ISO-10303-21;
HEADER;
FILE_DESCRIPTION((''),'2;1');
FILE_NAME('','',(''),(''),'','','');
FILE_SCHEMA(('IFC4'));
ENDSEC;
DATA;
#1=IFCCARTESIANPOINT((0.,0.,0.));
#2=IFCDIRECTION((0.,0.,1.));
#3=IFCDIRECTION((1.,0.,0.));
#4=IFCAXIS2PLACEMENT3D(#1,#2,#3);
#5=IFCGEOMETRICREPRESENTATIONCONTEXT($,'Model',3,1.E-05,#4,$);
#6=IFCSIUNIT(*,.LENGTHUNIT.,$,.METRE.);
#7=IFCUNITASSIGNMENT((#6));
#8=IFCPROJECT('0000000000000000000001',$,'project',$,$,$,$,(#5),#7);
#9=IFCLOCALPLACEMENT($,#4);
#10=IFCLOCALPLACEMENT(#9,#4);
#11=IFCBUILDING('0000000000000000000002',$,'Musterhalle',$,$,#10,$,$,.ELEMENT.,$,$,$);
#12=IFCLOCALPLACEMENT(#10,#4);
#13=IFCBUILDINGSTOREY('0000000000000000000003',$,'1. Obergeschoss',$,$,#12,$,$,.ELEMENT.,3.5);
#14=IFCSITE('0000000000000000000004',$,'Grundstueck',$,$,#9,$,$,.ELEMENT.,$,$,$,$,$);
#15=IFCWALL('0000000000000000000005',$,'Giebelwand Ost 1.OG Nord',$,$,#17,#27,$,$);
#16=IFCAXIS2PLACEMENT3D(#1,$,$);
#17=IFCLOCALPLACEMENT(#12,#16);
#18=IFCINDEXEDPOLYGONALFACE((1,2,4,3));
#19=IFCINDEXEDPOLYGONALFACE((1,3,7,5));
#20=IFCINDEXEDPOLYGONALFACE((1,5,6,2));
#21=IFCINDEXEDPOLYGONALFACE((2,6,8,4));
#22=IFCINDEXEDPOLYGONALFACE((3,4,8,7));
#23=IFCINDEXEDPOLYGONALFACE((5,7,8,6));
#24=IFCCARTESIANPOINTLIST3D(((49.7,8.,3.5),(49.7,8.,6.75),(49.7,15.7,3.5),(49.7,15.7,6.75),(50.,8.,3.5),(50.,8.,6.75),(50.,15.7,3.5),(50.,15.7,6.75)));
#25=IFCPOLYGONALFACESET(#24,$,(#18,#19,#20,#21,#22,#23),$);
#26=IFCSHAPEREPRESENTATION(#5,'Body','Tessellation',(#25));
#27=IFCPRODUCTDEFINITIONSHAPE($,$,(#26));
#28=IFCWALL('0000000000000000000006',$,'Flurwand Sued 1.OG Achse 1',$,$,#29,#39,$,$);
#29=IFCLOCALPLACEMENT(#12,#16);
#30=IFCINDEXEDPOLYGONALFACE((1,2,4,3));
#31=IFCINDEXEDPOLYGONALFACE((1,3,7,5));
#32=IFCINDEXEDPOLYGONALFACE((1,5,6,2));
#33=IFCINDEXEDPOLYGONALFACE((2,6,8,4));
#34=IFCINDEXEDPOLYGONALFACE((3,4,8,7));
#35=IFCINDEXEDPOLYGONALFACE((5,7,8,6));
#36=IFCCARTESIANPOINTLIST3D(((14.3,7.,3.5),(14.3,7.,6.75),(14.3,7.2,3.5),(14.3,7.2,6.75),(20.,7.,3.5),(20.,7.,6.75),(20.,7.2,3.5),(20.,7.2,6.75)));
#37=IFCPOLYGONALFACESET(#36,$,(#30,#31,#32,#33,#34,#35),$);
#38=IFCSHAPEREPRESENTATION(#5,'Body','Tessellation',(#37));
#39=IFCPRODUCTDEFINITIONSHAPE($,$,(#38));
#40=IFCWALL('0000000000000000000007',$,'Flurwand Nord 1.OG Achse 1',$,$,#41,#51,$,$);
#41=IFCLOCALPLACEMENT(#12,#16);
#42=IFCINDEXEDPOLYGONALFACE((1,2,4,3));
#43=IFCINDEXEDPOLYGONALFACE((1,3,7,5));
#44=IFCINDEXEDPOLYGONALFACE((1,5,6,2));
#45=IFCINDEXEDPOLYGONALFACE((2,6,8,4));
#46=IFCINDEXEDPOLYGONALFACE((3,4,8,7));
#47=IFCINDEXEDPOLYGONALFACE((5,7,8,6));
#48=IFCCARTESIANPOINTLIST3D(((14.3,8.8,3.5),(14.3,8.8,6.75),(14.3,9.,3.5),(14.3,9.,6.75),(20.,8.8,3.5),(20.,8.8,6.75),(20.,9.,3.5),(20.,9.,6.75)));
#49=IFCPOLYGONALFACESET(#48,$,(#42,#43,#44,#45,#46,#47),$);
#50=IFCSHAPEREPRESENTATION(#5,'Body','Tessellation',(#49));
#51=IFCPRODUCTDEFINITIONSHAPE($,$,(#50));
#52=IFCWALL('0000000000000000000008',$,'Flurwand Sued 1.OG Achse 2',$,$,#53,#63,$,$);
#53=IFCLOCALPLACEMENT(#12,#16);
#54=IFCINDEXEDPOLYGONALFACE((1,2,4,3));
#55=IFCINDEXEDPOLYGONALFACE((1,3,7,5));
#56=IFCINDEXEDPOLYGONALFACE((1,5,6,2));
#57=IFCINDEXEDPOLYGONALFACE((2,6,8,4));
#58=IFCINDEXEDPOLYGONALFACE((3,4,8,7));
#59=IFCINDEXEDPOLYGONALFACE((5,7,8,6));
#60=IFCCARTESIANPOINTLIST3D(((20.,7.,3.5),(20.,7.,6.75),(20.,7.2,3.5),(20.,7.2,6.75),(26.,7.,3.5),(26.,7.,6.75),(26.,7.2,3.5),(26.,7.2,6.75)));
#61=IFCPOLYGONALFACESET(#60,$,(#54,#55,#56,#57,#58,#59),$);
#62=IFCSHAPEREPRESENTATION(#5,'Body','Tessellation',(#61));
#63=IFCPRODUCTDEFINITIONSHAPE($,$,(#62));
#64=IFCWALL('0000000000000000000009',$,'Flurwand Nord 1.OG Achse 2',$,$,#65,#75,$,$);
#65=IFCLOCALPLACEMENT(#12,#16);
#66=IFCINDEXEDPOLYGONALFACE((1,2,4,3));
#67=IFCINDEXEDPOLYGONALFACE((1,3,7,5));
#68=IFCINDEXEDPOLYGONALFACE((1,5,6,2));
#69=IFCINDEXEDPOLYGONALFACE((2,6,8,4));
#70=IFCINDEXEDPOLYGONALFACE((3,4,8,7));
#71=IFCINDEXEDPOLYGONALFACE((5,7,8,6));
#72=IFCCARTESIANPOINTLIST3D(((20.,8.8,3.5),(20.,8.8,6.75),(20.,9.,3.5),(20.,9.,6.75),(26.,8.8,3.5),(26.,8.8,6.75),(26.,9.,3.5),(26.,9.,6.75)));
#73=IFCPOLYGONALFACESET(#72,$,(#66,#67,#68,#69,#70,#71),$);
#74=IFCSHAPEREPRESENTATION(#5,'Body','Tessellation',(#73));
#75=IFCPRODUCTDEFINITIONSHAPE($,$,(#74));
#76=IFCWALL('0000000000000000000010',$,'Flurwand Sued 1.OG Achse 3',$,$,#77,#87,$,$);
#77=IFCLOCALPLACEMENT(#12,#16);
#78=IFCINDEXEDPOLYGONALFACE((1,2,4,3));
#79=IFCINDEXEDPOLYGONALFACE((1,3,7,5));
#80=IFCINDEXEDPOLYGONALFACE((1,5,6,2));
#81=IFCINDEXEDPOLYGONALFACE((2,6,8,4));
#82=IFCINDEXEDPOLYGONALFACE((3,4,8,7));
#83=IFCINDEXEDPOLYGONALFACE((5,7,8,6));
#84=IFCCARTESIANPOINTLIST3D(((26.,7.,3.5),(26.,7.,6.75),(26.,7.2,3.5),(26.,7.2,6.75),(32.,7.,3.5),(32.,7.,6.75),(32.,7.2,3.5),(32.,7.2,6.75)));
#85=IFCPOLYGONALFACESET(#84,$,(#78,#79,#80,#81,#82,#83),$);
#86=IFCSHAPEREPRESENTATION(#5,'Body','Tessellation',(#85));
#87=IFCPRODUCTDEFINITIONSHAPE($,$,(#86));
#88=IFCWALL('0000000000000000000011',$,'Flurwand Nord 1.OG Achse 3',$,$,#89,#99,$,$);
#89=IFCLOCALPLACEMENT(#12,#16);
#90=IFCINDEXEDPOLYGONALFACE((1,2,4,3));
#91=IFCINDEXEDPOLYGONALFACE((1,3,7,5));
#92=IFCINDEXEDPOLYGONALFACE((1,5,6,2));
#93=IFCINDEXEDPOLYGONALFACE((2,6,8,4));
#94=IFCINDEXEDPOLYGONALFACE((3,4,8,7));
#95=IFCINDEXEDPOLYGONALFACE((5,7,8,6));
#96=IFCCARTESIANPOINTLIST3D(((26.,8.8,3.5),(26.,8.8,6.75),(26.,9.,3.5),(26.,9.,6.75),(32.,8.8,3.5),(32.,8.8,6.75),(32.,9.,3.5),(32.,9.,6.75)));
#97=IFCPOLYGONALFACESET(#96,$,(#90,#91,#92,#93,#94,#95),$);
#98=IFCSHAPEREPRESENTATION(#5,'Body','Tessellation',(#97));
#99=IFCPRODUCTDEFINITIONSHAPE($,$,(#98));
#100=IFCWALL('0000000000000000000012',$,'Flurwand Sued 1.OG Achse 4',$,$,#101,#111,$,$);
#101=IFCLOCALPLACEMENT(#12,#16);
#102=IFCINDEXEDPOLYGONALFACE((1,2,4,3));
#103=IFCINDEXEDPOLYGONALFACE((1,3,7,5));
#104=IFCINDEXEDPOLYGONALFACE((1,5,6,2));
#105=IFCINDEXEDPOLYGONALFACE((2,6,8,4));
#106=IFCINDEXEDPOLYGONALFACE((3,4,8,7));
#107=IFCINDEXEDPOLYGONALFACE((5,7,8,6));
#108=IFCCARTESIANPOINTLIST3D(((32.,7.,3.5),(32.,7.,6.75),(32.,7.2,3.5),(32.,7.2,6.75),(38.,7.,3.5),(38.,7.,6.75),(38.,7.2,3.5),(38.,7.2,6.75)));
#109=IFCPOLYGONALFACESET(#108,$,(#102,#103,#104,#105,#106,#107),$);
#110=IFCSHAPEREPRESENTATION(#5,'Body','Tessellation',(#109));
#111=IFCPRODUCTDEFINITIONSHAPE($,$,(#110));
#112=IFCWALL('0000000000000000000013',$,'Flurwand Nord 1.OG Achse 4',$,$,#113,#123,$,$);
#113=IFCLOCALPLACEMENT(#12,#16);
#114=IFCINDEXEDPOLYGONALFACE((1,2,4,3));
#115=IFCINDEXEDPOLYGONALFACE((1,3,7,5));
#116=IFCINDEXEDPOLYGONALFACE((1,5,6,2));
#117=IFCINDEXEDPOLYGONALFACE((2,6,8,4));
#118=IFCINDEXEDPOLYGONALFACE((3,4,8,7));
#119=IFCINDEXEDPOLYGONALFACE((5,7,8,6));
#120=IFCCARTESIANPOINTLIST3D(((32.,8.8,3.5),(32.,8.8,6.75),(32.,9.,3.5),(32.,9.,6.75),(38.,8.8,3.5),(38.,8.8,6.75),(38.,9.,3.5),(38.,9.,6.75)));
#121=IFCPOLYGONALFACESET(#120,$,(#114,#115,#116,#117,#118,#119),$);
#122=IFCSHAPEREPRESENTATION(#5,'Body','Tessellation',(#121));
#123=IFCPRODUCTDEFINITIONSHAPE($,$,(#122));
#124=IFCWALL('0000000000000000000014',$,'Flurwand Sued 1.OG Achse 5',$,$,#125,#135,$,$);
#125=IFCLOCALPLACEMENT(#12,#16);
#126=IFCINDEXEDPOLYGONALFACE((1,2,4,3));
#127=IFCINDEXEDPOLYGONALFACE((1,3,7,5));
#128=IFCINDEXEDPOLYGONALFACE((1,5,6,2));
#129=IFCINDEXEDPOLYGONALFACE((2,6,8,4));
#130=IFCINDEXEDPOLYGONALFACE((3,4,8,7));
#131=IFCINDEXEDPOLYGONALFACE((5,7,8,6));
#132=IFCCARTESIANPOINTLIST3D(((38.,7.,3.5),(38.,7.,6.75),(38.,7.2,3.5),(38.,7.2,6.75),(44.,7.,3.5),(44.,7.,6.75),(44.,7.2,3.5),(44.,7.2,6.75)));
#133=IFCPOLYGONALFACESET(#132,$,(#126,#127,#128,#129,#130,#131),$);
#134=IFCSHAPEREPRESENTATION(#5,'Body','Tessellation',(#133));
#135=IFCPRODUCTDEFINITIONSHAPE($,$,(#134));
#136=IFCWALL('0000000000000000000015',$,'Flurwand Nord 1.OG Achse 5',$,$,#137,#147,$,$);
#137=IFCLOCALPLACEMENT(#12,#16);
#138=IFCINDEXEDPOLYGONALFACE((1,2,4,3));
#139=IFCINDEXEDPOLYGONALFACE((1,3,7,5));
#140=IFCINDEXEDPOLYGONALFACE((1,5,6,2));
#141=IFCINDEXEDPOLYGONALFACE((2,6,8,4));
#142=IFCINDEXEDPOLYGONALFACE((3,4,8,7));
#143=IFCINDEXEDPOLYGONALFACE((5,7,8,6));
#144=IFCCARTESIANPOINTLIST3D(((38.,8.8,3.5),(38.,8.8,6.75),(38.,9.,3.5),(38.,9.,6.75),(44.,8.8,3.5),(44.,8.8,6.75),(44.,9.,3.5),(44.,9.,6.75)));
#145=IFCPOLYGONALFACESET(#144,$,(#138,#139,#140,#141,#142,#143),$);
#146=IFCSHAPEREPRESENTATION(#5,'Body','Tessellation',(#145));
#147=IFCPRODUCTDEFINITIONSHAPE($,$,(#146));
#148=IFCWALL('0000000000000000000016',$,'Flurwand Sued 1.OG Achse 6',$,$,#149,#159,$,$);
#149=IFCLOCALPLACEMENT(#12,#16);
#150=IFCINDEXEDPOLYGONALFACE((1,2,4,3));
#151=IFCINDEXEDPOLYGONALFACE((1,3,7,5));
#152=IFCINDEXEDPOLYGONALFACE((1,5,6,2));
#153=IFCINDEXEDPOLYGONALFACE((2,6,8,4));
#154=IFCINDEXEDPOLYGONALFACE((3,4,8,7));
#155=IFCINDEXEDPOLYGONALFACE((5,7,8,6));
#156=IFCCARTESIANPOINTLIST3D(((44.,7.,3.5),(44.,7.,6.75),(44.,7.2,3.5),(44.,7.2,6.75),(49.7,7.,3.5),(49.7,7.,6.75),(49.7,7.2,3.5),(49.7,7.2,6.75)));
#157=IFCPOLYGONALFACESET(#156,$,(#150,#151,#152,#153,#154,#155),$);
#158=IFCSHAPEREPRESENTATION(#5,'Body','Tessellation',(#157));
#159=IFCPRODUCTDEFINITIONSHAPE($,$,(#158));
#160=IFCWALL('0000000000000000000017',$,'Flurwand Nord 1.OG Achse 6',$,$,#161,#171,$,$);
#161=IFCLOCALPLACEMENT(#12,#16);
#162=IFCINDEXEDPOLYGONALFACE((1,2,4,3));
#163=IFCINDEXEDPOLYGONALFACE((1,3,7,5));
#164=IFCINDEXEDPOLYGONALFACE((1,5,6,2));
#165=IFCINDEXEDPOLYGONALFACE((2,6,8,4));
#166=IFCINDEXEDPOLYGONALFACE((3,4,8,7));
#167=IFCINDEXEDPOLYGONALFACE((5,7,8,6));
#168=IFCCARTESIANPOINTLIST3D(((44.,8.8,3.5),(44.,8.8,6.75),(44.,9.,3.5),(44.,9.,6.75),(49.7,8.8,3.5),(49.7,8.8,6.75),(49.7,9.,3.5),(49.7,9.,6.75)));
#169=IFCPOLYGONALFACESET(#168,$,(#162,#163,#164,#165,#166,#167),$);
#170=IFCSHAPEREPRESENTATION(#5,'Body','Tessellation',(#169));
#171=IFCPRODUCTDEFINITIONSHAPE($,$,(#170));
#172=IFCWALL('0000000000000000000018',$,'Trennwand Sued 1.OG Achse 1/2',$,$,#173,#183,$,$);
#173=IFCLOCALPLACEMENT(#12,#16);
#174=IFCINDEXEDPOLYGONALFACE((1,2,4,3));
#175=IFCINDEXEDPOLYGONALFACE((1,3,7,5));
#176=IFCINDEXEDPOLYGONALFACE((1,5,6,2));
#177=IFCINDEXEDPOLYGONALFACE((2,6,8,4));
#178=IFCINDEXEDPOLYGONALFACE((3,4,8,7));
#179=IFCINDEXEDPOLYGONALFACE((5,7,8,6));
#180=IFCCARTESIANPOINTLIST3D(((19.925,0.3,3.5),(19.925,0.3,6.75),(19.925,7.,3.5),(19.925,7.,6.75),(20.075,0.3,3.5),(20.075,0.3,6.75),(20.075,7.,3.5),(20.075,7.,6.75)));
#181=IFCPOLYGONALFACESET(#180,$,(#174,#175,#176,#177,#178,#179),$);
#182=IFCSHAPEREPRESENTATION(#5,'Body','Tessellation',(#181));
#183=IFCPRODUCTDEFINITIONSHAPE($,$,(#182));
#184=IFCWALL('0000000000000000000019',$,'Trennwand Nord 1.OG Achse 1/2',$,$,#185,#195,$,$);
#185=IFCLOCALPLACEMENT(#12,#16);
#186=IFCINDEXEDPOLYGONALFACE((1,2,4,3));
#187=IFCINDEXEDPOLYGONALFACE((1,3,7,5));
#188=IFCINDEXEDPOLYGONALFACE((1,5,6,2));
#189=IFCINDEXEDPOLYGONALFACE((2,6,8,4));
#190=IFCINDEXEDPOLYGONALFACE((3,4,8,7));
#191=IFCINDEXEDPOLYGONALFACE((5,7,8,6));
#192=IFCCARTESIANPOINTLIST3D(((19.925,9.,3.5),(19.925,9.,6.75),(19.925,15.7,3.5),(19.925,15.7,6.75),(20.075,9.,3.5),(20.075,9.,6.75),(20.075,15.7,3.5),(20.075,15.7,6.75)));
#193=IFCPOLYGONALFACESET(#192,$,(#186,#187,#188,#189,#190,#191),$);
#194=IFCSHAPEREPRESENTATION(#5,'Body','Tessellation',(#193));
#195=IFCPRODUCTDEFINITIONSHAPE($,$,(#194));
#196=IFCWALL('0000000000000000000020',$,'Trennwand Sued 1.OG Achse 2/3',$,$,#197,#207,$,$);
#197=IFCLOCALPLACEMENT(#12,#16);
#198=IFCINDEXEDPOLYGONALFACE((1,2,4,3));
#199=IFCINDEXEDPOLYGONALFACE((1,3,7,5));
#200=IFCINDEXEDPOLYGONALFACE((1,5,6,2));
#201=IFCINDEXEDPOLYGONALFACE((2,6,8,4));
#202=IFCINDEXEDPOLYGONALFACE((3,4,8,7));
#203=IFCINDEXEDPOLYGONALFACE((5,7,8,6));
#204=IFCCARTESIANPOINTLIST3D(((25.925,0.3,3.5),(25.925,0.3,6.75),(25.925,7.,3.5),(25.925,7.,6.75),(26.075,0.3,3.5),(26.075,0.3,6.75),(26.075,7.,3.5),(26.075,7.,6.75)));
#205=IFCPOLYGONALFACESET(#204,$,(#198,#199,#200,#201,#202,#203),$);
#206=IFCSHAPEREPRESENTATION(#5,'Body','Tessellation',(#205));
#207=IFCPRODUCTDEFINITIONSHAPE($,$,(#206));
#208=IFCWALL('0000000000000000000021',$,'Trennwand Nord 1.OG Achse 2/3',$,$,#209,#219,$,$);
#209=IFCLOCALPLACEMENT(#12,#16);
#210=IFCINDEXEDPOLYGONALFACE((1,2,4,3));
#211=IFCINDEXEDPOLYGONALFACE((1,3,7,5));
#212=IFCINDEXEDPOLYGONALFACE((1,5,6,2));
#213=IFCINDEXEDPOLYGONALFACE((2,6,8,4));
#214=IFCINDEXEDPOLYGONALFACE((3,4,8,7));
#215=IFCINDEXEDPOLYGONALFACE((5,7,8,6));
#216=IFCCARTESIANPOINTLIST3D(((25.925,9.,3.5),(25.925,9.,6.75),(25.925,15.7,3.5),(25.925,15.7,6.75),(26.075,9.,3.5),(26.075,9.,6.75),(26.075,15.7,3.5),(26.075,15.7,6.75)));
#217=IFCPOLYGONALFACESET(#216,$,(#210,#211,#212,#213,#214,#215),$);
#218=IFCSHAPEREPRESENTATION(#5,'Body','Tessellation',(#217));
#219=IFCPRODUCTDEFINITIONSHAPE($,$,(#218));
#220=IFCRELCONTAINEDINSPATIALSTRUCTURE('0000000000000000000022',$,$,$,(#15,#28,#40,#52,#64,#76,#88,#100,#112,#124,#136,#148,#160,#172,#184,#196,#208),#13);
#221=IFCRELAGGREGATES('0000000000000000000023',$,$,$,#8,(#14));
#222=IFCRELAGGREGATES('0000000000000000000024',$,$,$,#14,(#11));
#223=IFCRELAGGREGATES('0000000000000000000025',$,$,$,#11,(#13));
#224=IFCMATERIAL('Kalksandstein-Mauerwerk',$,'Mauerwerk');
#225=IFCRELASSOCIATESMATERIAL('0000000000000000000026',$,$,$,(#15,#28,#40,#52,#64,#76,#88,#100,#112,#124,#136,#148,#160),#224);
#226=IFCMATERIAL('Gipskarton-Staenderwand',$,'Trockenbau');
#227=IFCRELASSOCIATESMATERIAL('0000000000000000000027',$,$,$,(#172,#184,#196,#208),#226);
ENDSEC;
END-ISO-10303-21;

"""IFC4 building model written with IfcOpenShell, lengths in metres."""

from ifc_helpers import new_model, si_unit, frame, origin_with_axes, origin_2d, place, context, project, spatial, rectangle, extrude, material, element, save


model = new_model("IFC4")

# Units and contexts
model_context = context("Model", 3, precision=1e-05, world=origin_with_axes())
ifc_project = project(units=[si_unit("LENGTHUNIT", "METRE")], contexts=[model_context])

# Site, building, storey
site_placement = place(None, origin_with_axes())
site = spatial("IfcSite", under=ifc_project, at=site_placement, Name="Grundstueck", CompositionType="ELEMENT")
building_placement = place(site_placement, origin_with_axes())
building = spatial("IfcBuilding", under=site, at=building_placement, Name="Musterhalle", CompositionType="ELEMENT")
storey_placement = place(building_placement, origin_with_axes())
storey = spatial("IfcBuildingStorey", under=building, at=storey_placement, Name="1. Obergeschoss", CompositionType="ELEMENT", Elevation=3.5)

# Walls
ifc_material_1 = material(Name="Kalksandstein-Mauerwerk", Category="Mauerwerk")
placement = place(storey_placement, origin_with_axes())
element("IfcWall", 1, at=placement, inside=storey, material=ifc_material_1, Name="Giebelwand Ost 1.OG Nord", context=model_context, shape_type="SweptSolid", body=[
    extrude(rectangle(XDim=0.3, YDim=7.7, at=origin_2d()), frame((49.85, 11.85, 3.5), z_axis=(0.0, 0.0, 1.0), x_axis=(1.0, 0.0, 0.0)), (0.0, 0.0, 1.0), 3.25),
])
element("IfcWall", 2, at=placement, inside=storey, material=ifc_material_1, Name="Flurwand Sued 1.OG Achse 1", context=model_context, shape_type="SweptSolid", body=[
    extrude(rectangle(XDim=5.7, YDim=0.2, at=origin_2d()), frame((17.15, 7.1, 3.5), z_axis=(0.0, 0.0, 1.0), x_axis=(1.0, 0.0, 0.0)), (0.0, 0.0, 1.0), 3.25),
])
element("IfcWall", 3, at=placement, inside=storey, material=ifc_material_1, Name="Flurwand Nord 1.OG Achse 1", context=model_context, shape_type="SweptSolid", body=[
    extrude(rectangle(XDim=5.7, YDim=0.2, at=origin_2d()), frame((17.15, 8.9, 3.5), z_axis=(0.0, 0.0, 1.0), x_axis=(1.0, 0.0, 0.0)), (0.0, 0.0, 1.0), 3.25),
])
element("IfcWall", 4, at=placement, inside=storey, material=ifc_material_1, Name="Flurwand Sued 1.OG Achse 2", context=model_context, shape_type="SweptSolid", body=[
    extrude(rectangle(XDim=6.0, YDim=0.2, at=origin_2d()), frame((23.0, 7.1, 3.5), z_axis=(0.0, 0.0, 1.0), x_axis=(1.0, 0.0, 0.0)), (0.0, 0.0, 1.0), 3.25),
])
element("IfcWall", 5, at=placement, inside=storey, material=ifc_material_1, Name="Flurwand Nord 1.OG Achse 2", context=model_context, shape_type="SweptSolid", body=[
    extrude(rectangle(XDim=6.0, YDim=0.2, at=origin_2d()), frame((23.0, 8.9, 3.5), z_axis=(0.0, 0.0, 1.0), x_axis=(1.0, 0.0, 0.0)), (0.0, 0.0, 1.0), 3.25),
])
element("IfcWall", 6, at=placement, inside=storey, material=ifc_material_1, Name="Flurwand Sued 1.OG Achse 3", context=model_context, shape_type="SweptSolid", body=[
    extrude(rectangle(XDim=6.0, YDim=0.2, at=origin_2d()), frame((29.0, 7.1, 3.5), z_axis=(0.0, 0.0, 1.0), x_axis=(1.0, 0.0, 0.0)), (0.0, 0.0, 1.0), 3.25),
])
element("IfcWall", 7, at=placement, inside=storey, material=ifc_material_1, Name="Flurwand Nord 1.OG Achse 3", context=model_context, shape_type="SweptSolid", body=[
    extrude(rectangle(XDim=6.0, YDim=0.2, at=origin_2d()), frame((29.0, 8.9, 3.5), z_axis=(0.0, 0.0, 1.0), x_axis=(1.0, 0.0, 0.0)), (0.0, 0.0, 1.0), 3.25),
])
element("IfcWall", 8, at=placement, inside=storey, material=ifc_material_1, Name="Flurwand Sued 1.OG Achse 4", context=model_context, shape_type="SweptSolid", body=[
    extrude(rectangle(XDim=6.0, YDim=0.2, at=origin_2d()), frame((35.0, 7.1, 3.5), z_axis=(0.0, 0.0, 1.0), x_axis=(1.0, 0.0, 0.0)), (0.0, 0.0, 1.0), 3.25),
])
element("IfcWall", 9, at=placement, inside=storey, material=ifc_material_1, Name="Flurwand Nord 1.OG Achse 4", context=model_context, shape_type="SweptSolid", body=[
    extrude(rectangle(XDim=6.0, YDim=0.2, at=origin_2d()), frame((35.0, 8.9, 3.5), z_axis=(0.0, 0.0, 1.0), x_axis=(1.0, 0.0, 0.0)), (0.0, 0.0, 1.0), 3.25),
])
element("IfcWall", 10, at=placement, inside=storey, material=ifc_material_1, Name="Flurwand Sued 1.OG Achse 5", context=model_context, shape_type="SweptSolid", body=[
    extrude(rectangle(XDim=6.0, YDim=0.2, at=origin_2d()), frame((41.0, 7.1, 3.5), z_axis=(0.0, 0.0, 1.0), x_axis=(1.0, 0.0, 0.0)), (0.0, 0.0, 1.0), 3.25),
])
element("IfcWall", 11, at=placement, inside=storey, material=ifc_material_1, Name="Flurwand Nord 1.OG Achse 5", context=model_context, shape_type="SweptSolid", body=[
    extrude(rectangle(XDim=6.0, YDim=0.2, at=origin_2d()), frame((41.0, 8.9, 3.5), z_axis=(0.0, 0.0, 1.0), x_axis=(1.0, 0.0, 0.0)), (0.0, 0.0, 1.0), 3.25),
])
element("IfcWall", 12, at=placement, inside=storey, material=ifc_material_1, Name="Flurwand Sued 1.OG Achse 6", context=model_context, shape_type="SweptSolid", body=[
    extrude(rectangle(XDim=5.7, YDim=0.2, at=origin_2d()), frame((46.85, 7.1, 3.5), z_axis=(0.0, 0.0, 1.0), x_axis=(1.0, 0.0, 0.0)), (0.0, 0.0, 1.0), 3.25),
])
element("IfcWall", 13, at=placement, inside=storey, material=ifc_material_1, Name="Flurwand Nord 1.OG Achse 6", context=model_context, shape_type="SweptSolid", body=[
    extrude(rectangle(XDim=5.7, YDim=0.2, at=origin_2d()), frame((46.85, 8.9, 3.5), z_axis=(0.0, 0.0, 1.0), x_axis=(1.0, 0.0, 0.0)), (0.0, 0.0, 1.0), 3.25),
])
ifc_material_2 = material(Name="Gipskarton-Staenderwand", Category="Trockenbau")
element("IfcWall", 14, at=placement, inside=storey, material=ifc_material_2, Name="Trennwand Sued 1.OG Achse 1/2", context=model_context, shape_type="SweptSolid", body=[
    extrude(rectangle(XDim=0.15, YDim=6.7, at=origin_2d()), frame((20.0, 3.65, 3.5), z_axis=(0.0, 0.0, 1.0), x_axis=(1.0, 0.0, 0.0)), (0.0, 0.0, 1.0), 3.25),
])
element("IfcWall", 15, at=placement, inside=storey, material=ifc_material_2, Name="Trennwand Nord 1.OG Achse 1/2", context=model_context, shape_type="SweptSolid", body=[
    extrude(rectangle(XDim=0.15, YDim=6.7, at=origin_2d()), frame((20.0, 12.35, 3.5), z_axis=(0.0, 0.0, 1.0), x_axis=(1.0, 0.0, 0.0)), (0.0, 0.0, 1.0), 3.25),
])
element("IfcWall", 16, at=placement, inside=storey, material=ifc_material_2, Name="Trennwand Sued 1.OG Achse 2/3", context=model_context, shape_type="SweptSolid", body=[
    extrude(rectangle(XDim=0.15, YDim=6.7, at=origin_2d()), frame((26.0, 3.65, 3.5), z_axis=(0.0, 0.0, 1.0), x_axis=(1.0, 0.0, 0.0)), (0.0, 0.0, 1.0), 3.25),
])
element("IfcWall", 17, at=placement, inside=storey, material=ifc_material_2, Name="Trennwand Nord 1.OG Achse 2/3", context=model_context, shape_type="SweptSolid", body=[
    extrude(rectangle(XDim=0.15, YDim=6.7, at=origin_2d()), frame((26.0, 12.35, 3.5), z_axis=(0.0, 0.0, 1.0), x_axis=(1.0, 0.0, 0.0)), (0.0, 0.0, 1.0), 3.25),
])

save(model, "model.ifc")
